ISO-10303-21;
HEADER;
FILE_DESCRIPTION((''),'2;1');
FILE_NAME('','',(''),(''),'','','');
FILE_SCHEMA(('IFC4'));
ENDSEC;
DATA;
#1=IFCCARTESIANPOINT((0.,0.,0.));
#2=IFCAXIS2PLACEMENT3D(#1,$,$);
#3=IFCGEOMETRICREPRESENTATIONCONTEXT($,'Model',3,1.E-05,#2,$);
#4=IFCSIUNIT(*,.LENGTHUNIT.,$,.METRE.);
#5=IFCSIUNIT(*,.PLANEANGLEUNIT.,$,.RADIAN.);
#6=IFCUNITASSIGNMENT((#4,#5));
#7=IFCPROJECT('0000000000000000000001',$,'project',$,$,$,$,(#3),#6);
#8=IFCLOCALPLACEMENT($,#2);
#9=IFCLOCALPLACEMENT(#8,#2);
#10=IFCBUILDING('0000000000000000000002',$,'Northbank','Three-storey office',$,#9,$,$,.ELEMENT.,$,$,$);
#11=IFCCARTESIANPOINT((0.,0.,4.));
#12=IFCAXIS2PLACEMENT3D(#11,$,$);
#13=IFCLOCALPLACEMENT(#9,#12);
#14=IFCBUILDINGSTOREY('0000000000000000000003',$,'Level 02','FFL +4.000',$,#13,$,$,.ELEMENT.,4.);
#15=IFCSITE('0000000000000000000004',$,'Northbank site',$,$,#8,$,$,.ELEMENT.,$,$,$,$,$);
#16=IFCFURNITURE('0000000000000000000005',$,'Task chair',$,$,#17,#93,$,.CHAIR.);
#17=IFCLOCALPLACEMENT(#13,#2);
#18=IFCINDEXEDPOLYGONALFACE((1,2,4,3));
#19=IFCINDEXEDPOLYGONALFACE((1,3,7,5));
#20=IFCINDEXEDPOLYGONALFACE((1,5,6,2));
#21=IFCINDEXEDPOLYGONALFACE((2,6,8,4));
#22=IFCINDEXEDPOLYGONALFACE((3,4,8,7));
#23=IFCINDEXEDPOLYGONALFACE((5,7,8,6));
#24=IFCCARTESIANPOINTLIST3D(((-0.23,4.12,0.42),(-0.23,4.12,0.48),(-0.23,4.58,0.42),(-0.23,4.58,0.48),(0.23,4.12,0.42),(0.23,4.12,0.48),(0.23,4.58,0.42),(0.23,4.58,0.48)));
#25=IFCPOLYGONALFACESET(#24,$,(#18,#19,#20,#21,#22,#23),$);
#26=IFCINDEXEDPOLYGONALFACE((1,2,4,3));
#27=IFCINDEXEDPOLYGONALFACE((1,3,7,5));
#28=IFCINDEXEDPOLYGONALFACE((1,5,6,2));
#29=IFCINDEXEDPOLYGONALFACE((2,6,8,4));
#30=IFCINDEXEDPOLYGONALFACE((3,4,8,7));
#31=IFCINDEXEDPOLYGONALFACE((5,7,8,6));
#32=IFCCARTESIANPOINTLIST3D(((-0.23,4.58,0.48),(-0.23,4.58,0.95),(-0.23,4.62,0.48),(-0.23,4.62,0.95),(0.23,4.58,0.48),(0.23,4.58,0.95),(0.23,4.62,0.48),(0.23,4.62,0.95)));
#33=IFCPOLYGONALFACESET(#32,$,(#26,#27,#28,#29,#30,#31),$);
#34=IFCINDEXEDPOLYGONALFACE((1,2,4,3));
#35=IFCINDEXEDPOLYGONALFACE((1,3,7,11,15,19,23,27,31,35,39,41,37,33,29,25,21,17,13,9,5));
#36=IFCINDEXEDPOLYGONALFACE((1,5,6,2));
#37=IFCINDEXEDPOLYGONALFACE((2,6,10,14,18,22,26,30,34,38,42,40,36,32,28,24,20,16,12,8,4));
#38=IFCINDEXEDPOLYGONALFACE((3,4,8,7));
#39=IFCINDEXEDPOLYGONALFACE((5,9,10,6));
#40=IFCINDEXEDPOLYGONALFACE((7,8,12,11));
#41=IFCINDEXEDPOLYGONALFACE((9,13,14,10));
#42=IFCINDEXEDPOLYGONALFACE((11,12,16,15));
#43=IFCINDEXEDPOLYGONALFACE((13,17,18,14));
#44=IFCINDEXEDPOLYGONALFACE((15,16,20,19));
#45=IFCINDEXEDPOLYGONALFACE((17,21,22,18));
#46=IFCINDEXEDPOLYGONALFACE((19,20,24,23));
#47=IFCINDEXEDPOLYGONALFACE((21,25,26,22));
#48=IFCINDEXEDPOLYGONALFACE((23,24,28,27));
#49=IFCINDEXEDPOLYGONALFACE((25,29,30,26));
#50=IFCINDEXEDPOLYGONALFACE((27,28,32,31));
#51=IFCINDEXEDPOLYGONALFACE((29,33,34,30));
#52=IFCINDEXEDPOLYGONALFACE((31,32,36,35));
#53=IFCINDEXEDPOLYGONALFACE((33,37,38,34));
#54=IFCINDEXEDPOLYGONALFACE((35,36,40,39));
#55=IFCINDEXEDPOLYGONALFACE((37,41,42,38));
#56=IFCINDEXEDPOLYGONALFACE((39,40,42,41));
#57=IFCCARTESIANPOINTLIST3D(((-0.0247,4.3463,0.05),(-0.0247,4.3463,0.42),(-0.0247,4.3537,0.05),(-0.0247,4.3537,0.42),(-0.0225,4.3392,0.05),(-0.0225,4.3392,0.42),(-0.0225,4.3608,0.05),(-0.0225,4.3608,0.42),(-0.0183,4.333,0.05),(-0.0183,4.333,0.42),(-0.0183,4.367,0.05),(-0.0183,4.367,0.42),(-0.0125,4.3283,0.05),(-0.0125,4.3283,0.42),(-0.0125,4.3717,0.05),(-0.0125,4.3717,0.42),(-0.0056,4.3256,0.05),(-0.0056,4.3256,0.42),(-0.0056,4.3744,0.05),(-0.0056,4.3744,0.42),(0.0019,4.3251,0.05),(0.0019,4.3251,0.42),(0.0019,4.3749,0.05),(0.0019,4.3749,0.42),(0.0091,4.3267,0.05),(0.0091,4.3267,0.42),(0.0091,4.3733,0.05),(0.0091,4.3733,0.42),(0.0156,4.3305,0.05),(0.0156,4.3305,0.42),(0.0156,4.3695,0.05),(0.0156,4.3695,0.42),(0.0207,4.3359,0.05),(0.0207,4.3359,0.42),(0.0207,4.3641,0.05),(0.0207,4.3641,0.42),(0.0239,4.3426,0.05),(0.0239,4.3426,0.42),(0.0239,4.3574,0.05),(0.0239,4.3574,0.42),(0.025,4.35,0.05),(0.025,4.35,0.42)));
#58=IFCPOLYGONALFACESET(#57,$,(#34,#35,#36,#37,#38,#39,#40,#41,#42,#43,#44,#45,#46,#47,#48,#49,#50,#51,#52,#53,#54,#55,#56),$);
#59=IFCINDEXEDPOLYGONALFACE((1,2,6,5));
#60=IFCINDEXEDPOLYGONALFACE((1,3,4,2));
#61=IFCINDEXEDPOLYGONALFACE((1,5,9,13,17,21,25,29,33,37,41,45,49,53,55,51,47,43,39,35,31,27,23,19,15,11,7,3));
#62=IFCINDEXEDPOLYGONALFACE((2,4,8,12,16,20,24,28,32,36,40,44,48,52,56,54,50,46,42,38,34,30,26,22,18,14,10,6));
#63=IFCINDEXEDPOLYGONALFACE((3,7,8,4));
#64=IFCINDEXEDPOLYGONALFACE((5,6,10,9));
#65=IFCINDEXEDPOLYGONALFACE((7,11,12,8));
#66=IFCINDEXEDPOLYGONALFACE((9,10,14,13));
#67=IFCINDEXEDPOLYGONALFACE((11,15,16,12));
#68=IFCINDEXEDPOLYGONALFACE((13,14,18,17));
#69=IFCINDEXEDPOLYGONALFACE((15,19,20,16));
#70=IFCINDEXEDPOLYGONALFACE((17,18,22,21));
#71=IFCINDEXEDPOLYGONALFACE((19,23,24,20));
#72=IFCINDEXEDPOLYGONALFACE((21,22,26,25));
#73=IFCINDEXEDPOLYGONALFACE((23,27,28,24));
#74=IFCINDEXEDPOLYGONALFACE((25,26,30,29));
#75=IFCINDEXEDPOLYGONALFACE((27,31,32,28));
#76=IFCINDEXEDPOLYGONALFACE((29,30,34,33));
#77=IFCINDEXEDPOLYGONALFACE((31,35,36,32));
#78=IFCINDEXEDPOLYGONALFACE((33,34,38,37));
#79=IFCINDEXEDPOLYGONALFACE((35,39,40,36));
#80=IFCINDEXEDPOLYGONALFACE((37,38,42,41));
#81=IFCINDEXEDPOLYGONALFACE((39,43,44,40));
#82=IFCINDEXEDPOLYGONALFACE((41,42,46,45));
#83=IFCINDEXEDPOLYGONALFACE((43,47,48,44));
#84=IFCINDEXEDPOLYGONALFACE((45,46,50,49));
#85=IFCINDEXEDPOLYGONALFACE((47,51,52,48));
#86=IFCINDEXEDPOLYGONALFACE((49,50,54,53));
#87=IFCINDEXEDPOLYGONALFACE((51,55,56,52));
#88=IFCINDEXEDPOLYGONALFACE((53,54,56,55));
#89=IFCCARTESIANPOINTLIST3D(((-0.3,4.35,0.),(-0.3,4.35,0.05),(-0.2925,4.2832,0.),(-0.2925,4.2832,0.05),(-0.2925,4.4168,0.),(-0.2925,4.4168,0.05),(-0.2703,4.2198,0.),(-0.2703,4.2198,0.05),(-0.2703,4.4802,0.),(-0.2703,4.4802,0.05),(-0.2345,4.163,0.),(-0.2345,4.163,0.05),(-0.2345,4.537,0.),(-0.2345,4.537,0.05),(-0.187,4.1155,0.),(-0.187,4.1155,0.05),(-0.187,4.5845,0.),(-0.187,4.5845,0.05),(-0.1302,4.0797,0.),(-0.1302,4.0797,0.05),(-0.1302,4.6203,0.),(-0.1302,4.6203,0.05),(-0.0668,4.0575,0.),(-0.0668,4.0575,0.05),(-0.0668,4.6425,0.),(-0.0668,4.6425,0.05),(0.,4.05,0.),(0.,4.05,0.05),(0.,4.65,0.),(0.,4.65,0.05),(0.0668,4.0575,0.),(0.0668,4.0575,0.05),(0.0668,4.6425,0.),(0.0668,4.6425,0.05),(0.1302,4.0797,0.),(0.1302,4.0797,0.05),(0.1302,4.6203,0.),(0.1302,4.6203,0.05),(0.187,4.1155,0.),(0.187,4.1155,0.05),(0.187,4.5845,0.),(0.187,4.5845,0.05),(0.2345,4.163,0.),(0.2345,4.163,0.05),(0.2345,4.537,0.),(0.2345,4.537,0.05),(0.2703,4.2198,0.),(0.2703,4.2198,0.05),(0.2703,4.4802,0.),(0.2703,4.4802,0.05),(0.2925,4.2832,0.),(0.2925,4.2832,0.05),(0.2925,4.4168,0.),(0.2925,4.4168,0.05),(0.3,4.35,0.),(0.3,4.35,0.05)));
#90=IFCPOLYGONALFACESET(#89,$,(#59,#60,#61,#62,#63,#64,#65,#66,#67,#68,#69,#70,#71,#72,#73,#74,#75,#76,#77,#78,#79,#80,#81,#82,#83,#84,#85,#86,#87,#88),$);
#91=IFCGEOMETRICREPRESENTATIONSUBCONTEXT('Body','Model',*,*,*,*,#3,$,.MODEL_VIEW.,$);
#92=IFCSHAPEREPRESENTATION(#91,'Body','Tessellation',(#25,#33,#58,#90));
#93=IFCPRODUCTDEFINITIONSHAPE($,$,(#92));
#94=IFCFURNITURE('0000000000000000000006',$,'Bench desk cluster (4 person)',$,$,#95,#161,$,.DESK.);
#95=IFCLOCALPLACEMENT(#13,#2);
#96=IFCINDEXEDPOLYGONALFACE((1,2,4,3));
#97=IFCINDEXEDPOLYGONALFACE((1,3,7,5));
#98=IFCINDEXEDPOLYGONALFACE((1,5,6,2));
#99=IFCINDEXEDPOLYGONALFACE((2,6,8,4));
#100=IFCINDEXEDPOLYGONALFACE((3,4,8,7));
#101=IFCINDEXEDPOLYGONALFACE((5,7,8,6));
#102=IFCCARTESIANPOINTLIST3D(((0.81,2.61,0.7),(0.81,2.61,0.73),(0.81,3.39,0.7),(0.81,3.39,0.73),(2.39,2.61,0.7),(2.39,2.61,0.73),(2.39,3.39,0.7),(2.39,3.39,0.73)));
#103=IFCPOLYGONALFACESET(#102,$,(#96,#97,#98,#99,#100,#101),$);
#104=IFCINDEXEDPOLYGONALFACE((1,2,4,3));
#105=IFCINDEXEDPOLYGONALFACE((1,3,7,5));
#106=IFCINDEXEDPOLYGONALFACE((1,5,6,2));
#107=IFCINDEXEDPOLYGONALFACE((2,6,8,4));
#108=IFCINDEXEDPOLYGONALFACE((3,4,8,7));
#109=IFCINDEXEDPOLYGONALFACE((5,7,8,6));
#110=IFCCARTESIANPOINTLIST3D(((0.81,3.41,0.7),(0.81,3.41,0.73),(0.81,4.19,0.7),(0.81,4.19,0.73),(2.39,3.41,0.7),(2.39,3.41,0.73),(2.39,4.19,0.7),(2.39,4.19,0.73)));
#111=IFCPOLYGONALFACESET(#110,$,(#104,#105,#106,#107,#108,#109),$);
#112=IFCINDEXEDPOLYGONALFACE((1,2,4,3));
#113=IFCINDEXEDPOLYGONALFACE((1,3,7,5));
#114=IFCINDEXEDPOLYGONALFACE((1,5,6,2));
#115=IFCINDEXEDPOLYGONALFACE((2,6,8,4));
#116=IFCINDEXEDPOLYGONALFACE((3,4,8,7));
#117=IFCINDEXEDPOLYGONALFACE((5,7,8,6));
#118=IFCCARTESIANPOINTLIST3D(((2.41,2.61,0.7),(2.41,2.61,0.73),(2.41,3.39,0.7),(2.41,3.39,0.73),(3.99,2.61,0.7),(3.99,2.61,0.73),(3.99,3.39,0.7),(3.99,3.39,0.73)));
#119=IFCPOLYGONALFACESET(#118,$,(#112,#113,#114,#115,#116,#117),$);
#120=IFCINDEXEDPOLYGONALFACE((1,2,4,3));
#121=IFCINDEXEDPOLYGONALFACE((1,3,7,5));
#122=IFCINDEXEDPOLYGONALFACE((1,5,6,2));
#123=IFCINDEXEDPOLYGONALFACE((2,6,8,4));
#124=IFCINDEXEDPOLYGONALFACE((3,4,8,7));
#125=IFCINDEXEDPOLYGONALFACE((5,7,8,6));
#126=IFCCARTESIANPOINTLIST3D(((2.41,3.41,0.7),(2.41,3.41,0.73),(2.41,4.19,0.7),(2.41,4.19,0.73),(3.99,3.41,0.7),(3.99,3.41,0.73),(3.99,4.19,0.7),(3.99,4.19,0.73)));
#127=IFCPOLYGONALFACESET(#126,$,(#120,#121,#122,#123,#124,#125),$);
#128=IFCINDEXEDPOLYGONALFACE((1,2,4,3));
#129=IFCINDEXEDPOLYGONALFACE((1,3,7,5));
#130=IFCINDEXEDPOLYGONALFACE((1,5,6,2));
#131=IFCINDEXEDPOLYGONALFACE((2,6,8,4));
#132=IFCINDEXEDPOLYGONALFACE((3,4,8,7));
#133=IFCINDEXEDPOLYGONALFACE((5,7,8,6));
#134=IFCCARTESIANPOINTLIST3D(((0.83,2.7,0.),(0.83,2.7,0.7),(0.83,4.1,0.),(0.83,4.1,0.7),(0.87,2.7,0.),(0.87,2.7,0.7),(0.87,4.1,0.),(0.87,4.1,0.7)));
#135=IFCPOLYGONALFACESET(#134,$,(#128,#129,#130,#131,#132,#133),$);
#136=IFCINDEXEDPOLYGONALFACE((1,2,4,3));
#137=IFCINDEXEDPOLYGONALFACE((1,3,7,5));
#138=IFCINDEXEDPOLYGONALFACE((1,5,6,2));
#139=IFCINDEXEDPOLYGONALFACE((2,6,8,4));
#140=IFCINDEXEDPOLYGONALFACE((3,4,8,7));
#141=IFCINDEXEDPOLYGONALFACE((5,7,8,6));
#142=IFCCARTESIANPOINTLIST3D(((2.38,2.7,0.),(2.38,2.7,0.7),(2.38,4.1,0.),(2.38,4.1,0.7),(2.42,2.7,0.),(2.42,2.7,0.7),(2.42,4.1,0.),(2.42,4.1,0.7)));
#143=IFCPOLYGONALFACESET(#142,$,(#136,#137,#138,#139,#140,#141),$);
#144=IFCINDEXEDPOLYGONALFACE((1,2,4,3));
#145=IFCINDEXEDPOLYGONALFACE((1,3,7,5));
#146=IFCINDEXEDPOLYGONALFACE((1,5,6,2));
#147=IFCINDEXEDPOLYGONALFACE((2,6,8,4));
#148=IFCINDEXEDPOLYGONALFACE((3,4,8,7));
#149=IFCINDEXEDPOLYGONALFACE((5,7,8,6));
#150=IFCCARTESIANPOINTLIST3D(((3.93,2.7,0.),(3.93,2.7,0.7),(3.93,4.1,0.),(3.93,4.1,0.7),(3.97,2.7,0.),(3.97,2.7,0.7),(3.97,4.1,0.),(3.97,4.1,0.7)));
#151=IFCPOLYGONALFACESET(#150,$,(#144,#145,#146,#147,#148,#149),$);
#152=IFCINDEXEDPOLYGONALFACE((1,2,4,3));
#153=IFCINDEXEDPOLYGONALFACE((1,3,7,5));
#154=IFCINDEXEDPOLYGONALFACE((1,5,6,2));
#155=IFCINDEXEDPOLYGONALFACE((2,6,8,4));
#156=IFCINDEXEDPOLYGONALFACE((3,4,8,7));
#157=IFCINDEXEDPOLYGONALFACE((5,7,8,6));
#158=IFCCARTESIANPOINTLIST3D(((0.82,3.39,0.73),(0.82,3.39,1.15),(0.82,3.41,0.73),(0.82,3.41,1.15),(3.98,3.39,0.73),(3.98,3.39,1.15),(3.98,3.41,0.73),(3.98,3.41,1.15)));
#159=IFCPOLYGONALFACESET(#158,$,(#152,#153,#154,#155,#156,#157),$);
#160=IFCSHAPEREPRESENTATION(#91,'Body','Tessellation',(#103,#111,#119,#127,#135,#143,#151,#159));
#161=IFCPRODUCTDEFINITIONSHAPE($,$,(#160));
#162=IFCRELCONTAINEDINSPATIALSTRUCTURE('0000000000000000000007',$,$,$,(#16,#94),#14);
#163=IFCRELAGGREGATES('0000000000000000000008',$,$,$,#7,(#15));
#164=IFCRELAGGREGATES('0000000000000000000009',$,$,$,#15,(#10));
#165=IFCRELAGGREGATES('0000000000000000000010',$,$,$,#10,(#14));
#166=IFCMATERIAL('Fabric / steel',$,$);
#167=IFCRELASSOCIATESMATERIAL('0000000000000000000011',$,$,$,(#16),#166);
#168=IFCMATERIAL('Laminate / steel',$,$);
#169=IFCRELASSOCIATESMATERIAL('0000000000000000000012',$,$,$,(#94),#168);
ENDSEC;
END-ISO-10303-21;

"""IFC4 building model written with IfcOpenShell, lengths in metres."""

from ifc_helpers import new_model, si_unit, frame, origin, place, context, subcontext, project, spatial, rectangle, circle, extrude, material, element, save


model = new_model("IFC4")

# Units and contexts
model_context = context("Model", 3, precision=1e-05, world=origin())
body_context = subcontext(model_context, "Body", "Model", "MODEL_VIEW")
ifc_project = project(units=[si_unit("LENGTHUNIT", "METRE"), si_unit("PLANEANGLEUNIT", "RADIAN")], contexts=[model_context])

# Site, building, storey
site_placement = place(None, origin())
site = spatial("IfcSite", under=ifc_project, at=site_placement, Name="Northbank site", CompositionType="ELEMENT")
building_placement = place(site_placement, origin())
building = spatial("IfcBuilding", under=site, at=building_placement, Name="Northbank", Description="Three-storey office", CompositionType="ELEMENT")
storey_placement = place(building_placement, frame((0.0, 0.0, 4.0)))
storey = spatial("IfcBuildingStorey", under=building, at=storey_placement, Name="Level 02", Description="FFL +4.000", CompositionType="ELEMENT", Elevation=4.0)

# Furniture
ifc_material_1 = material(Name="Laminate / steel")
ifc_material_2 = material(Name="Fabric / steel")
furniture_1_placement = place(storey_placement, frame((0.0, 0.0, -4.0)))
element("IfcFurniture", 1, at=furniture_1_placement, inside=storey, material=ifc_material_2, Name="Task chair", PredefinedType="CHAIR", context=body_context, shape_type="SweptSolid", body=[
    extrude(rectangle(XDim=0.46, YDim=0.46), frame((0.0, 4.35, 4.42)), (0.0, 0.0, 1.0), 0.06),
    extrude(rectangle(XDim=0.46, YDim=0.04), frame((0.0, 4.6, 4.48)), (0.0, 0.0, 1.0), 0.47),
    extrude(circle(Radius=0.025), frame((0.0, 4.35, 4.05), z_axis=(0.0, 0.0, 1.0), x_axis=(1.0, 0.0, 0.0)), (0.0, 0.0, 1.0), 0.37),
    extrude(circle(Radius=0.3), frame((0.0, 4.35, 4.0), z_axis=(0.0, 0.0, 1.0), x_axis=(1.0, 0.0, 0.0)), (0.0, 0.0, 1.0), 0.05),
])
furniture_2_placement = place(storey_placement, frame((0.0, 0.0, -4.0)))
element("IfcFurniture", 2, at=furniture_2_placement, inside=storey, material=ifc_material_1, Name="Bench desk cluster (4 person)", PredefinedType="DESK", context=body_context, shape_type="SweptSolid", body=[
    extrude(rectangle(XDim=1.58, YDim=0.78), frame((1.6, 3.0, 4.7)), (0.0, 0.0, 1.0), 0.03),
    extrude(rectangle(XDim=1.58, YDim=0.78), frame((1.6, 3.8, 4.7)), (0.0, 0.0, 1.0), 0.03),
    extrude(rectangle(XDim=1.58, YDim=0.78), frame((3.2, 3.0, 4.7)), (0.0, 0.0, 1.0), 0.03),
    extrude(rectangle(XDim=1.58, YDim=0.78), frame((3.2, 3.8, 4.7)), (0.0, 0.0, 1.0), 0.03),
    extrude(rectangle(XDim=0.04, YDim=1.4), frame((0.85, 3.4, 4.0)), (0.0, 0.0, 1.0), 0.7),
    extrude(rectangle(XDim=0.04, YDim=1.4), frame((2.4, 3.4, 4.0)), (0.0, 0.0, 1.0), 0.7),
    extrude(rectangle(XDim=0.04, YDim=1.4), frame((3.95, 3.4, 4.0)), (0.0, 0.0, 1.0), 0.7),
    extrude(rectangle(XDim=3.16, YDim=0.02), frame((2.4, 3.4, 4.73)), (0.0, 0.0, 1.0), 0.42),
])

save(model, "model.ifc")
